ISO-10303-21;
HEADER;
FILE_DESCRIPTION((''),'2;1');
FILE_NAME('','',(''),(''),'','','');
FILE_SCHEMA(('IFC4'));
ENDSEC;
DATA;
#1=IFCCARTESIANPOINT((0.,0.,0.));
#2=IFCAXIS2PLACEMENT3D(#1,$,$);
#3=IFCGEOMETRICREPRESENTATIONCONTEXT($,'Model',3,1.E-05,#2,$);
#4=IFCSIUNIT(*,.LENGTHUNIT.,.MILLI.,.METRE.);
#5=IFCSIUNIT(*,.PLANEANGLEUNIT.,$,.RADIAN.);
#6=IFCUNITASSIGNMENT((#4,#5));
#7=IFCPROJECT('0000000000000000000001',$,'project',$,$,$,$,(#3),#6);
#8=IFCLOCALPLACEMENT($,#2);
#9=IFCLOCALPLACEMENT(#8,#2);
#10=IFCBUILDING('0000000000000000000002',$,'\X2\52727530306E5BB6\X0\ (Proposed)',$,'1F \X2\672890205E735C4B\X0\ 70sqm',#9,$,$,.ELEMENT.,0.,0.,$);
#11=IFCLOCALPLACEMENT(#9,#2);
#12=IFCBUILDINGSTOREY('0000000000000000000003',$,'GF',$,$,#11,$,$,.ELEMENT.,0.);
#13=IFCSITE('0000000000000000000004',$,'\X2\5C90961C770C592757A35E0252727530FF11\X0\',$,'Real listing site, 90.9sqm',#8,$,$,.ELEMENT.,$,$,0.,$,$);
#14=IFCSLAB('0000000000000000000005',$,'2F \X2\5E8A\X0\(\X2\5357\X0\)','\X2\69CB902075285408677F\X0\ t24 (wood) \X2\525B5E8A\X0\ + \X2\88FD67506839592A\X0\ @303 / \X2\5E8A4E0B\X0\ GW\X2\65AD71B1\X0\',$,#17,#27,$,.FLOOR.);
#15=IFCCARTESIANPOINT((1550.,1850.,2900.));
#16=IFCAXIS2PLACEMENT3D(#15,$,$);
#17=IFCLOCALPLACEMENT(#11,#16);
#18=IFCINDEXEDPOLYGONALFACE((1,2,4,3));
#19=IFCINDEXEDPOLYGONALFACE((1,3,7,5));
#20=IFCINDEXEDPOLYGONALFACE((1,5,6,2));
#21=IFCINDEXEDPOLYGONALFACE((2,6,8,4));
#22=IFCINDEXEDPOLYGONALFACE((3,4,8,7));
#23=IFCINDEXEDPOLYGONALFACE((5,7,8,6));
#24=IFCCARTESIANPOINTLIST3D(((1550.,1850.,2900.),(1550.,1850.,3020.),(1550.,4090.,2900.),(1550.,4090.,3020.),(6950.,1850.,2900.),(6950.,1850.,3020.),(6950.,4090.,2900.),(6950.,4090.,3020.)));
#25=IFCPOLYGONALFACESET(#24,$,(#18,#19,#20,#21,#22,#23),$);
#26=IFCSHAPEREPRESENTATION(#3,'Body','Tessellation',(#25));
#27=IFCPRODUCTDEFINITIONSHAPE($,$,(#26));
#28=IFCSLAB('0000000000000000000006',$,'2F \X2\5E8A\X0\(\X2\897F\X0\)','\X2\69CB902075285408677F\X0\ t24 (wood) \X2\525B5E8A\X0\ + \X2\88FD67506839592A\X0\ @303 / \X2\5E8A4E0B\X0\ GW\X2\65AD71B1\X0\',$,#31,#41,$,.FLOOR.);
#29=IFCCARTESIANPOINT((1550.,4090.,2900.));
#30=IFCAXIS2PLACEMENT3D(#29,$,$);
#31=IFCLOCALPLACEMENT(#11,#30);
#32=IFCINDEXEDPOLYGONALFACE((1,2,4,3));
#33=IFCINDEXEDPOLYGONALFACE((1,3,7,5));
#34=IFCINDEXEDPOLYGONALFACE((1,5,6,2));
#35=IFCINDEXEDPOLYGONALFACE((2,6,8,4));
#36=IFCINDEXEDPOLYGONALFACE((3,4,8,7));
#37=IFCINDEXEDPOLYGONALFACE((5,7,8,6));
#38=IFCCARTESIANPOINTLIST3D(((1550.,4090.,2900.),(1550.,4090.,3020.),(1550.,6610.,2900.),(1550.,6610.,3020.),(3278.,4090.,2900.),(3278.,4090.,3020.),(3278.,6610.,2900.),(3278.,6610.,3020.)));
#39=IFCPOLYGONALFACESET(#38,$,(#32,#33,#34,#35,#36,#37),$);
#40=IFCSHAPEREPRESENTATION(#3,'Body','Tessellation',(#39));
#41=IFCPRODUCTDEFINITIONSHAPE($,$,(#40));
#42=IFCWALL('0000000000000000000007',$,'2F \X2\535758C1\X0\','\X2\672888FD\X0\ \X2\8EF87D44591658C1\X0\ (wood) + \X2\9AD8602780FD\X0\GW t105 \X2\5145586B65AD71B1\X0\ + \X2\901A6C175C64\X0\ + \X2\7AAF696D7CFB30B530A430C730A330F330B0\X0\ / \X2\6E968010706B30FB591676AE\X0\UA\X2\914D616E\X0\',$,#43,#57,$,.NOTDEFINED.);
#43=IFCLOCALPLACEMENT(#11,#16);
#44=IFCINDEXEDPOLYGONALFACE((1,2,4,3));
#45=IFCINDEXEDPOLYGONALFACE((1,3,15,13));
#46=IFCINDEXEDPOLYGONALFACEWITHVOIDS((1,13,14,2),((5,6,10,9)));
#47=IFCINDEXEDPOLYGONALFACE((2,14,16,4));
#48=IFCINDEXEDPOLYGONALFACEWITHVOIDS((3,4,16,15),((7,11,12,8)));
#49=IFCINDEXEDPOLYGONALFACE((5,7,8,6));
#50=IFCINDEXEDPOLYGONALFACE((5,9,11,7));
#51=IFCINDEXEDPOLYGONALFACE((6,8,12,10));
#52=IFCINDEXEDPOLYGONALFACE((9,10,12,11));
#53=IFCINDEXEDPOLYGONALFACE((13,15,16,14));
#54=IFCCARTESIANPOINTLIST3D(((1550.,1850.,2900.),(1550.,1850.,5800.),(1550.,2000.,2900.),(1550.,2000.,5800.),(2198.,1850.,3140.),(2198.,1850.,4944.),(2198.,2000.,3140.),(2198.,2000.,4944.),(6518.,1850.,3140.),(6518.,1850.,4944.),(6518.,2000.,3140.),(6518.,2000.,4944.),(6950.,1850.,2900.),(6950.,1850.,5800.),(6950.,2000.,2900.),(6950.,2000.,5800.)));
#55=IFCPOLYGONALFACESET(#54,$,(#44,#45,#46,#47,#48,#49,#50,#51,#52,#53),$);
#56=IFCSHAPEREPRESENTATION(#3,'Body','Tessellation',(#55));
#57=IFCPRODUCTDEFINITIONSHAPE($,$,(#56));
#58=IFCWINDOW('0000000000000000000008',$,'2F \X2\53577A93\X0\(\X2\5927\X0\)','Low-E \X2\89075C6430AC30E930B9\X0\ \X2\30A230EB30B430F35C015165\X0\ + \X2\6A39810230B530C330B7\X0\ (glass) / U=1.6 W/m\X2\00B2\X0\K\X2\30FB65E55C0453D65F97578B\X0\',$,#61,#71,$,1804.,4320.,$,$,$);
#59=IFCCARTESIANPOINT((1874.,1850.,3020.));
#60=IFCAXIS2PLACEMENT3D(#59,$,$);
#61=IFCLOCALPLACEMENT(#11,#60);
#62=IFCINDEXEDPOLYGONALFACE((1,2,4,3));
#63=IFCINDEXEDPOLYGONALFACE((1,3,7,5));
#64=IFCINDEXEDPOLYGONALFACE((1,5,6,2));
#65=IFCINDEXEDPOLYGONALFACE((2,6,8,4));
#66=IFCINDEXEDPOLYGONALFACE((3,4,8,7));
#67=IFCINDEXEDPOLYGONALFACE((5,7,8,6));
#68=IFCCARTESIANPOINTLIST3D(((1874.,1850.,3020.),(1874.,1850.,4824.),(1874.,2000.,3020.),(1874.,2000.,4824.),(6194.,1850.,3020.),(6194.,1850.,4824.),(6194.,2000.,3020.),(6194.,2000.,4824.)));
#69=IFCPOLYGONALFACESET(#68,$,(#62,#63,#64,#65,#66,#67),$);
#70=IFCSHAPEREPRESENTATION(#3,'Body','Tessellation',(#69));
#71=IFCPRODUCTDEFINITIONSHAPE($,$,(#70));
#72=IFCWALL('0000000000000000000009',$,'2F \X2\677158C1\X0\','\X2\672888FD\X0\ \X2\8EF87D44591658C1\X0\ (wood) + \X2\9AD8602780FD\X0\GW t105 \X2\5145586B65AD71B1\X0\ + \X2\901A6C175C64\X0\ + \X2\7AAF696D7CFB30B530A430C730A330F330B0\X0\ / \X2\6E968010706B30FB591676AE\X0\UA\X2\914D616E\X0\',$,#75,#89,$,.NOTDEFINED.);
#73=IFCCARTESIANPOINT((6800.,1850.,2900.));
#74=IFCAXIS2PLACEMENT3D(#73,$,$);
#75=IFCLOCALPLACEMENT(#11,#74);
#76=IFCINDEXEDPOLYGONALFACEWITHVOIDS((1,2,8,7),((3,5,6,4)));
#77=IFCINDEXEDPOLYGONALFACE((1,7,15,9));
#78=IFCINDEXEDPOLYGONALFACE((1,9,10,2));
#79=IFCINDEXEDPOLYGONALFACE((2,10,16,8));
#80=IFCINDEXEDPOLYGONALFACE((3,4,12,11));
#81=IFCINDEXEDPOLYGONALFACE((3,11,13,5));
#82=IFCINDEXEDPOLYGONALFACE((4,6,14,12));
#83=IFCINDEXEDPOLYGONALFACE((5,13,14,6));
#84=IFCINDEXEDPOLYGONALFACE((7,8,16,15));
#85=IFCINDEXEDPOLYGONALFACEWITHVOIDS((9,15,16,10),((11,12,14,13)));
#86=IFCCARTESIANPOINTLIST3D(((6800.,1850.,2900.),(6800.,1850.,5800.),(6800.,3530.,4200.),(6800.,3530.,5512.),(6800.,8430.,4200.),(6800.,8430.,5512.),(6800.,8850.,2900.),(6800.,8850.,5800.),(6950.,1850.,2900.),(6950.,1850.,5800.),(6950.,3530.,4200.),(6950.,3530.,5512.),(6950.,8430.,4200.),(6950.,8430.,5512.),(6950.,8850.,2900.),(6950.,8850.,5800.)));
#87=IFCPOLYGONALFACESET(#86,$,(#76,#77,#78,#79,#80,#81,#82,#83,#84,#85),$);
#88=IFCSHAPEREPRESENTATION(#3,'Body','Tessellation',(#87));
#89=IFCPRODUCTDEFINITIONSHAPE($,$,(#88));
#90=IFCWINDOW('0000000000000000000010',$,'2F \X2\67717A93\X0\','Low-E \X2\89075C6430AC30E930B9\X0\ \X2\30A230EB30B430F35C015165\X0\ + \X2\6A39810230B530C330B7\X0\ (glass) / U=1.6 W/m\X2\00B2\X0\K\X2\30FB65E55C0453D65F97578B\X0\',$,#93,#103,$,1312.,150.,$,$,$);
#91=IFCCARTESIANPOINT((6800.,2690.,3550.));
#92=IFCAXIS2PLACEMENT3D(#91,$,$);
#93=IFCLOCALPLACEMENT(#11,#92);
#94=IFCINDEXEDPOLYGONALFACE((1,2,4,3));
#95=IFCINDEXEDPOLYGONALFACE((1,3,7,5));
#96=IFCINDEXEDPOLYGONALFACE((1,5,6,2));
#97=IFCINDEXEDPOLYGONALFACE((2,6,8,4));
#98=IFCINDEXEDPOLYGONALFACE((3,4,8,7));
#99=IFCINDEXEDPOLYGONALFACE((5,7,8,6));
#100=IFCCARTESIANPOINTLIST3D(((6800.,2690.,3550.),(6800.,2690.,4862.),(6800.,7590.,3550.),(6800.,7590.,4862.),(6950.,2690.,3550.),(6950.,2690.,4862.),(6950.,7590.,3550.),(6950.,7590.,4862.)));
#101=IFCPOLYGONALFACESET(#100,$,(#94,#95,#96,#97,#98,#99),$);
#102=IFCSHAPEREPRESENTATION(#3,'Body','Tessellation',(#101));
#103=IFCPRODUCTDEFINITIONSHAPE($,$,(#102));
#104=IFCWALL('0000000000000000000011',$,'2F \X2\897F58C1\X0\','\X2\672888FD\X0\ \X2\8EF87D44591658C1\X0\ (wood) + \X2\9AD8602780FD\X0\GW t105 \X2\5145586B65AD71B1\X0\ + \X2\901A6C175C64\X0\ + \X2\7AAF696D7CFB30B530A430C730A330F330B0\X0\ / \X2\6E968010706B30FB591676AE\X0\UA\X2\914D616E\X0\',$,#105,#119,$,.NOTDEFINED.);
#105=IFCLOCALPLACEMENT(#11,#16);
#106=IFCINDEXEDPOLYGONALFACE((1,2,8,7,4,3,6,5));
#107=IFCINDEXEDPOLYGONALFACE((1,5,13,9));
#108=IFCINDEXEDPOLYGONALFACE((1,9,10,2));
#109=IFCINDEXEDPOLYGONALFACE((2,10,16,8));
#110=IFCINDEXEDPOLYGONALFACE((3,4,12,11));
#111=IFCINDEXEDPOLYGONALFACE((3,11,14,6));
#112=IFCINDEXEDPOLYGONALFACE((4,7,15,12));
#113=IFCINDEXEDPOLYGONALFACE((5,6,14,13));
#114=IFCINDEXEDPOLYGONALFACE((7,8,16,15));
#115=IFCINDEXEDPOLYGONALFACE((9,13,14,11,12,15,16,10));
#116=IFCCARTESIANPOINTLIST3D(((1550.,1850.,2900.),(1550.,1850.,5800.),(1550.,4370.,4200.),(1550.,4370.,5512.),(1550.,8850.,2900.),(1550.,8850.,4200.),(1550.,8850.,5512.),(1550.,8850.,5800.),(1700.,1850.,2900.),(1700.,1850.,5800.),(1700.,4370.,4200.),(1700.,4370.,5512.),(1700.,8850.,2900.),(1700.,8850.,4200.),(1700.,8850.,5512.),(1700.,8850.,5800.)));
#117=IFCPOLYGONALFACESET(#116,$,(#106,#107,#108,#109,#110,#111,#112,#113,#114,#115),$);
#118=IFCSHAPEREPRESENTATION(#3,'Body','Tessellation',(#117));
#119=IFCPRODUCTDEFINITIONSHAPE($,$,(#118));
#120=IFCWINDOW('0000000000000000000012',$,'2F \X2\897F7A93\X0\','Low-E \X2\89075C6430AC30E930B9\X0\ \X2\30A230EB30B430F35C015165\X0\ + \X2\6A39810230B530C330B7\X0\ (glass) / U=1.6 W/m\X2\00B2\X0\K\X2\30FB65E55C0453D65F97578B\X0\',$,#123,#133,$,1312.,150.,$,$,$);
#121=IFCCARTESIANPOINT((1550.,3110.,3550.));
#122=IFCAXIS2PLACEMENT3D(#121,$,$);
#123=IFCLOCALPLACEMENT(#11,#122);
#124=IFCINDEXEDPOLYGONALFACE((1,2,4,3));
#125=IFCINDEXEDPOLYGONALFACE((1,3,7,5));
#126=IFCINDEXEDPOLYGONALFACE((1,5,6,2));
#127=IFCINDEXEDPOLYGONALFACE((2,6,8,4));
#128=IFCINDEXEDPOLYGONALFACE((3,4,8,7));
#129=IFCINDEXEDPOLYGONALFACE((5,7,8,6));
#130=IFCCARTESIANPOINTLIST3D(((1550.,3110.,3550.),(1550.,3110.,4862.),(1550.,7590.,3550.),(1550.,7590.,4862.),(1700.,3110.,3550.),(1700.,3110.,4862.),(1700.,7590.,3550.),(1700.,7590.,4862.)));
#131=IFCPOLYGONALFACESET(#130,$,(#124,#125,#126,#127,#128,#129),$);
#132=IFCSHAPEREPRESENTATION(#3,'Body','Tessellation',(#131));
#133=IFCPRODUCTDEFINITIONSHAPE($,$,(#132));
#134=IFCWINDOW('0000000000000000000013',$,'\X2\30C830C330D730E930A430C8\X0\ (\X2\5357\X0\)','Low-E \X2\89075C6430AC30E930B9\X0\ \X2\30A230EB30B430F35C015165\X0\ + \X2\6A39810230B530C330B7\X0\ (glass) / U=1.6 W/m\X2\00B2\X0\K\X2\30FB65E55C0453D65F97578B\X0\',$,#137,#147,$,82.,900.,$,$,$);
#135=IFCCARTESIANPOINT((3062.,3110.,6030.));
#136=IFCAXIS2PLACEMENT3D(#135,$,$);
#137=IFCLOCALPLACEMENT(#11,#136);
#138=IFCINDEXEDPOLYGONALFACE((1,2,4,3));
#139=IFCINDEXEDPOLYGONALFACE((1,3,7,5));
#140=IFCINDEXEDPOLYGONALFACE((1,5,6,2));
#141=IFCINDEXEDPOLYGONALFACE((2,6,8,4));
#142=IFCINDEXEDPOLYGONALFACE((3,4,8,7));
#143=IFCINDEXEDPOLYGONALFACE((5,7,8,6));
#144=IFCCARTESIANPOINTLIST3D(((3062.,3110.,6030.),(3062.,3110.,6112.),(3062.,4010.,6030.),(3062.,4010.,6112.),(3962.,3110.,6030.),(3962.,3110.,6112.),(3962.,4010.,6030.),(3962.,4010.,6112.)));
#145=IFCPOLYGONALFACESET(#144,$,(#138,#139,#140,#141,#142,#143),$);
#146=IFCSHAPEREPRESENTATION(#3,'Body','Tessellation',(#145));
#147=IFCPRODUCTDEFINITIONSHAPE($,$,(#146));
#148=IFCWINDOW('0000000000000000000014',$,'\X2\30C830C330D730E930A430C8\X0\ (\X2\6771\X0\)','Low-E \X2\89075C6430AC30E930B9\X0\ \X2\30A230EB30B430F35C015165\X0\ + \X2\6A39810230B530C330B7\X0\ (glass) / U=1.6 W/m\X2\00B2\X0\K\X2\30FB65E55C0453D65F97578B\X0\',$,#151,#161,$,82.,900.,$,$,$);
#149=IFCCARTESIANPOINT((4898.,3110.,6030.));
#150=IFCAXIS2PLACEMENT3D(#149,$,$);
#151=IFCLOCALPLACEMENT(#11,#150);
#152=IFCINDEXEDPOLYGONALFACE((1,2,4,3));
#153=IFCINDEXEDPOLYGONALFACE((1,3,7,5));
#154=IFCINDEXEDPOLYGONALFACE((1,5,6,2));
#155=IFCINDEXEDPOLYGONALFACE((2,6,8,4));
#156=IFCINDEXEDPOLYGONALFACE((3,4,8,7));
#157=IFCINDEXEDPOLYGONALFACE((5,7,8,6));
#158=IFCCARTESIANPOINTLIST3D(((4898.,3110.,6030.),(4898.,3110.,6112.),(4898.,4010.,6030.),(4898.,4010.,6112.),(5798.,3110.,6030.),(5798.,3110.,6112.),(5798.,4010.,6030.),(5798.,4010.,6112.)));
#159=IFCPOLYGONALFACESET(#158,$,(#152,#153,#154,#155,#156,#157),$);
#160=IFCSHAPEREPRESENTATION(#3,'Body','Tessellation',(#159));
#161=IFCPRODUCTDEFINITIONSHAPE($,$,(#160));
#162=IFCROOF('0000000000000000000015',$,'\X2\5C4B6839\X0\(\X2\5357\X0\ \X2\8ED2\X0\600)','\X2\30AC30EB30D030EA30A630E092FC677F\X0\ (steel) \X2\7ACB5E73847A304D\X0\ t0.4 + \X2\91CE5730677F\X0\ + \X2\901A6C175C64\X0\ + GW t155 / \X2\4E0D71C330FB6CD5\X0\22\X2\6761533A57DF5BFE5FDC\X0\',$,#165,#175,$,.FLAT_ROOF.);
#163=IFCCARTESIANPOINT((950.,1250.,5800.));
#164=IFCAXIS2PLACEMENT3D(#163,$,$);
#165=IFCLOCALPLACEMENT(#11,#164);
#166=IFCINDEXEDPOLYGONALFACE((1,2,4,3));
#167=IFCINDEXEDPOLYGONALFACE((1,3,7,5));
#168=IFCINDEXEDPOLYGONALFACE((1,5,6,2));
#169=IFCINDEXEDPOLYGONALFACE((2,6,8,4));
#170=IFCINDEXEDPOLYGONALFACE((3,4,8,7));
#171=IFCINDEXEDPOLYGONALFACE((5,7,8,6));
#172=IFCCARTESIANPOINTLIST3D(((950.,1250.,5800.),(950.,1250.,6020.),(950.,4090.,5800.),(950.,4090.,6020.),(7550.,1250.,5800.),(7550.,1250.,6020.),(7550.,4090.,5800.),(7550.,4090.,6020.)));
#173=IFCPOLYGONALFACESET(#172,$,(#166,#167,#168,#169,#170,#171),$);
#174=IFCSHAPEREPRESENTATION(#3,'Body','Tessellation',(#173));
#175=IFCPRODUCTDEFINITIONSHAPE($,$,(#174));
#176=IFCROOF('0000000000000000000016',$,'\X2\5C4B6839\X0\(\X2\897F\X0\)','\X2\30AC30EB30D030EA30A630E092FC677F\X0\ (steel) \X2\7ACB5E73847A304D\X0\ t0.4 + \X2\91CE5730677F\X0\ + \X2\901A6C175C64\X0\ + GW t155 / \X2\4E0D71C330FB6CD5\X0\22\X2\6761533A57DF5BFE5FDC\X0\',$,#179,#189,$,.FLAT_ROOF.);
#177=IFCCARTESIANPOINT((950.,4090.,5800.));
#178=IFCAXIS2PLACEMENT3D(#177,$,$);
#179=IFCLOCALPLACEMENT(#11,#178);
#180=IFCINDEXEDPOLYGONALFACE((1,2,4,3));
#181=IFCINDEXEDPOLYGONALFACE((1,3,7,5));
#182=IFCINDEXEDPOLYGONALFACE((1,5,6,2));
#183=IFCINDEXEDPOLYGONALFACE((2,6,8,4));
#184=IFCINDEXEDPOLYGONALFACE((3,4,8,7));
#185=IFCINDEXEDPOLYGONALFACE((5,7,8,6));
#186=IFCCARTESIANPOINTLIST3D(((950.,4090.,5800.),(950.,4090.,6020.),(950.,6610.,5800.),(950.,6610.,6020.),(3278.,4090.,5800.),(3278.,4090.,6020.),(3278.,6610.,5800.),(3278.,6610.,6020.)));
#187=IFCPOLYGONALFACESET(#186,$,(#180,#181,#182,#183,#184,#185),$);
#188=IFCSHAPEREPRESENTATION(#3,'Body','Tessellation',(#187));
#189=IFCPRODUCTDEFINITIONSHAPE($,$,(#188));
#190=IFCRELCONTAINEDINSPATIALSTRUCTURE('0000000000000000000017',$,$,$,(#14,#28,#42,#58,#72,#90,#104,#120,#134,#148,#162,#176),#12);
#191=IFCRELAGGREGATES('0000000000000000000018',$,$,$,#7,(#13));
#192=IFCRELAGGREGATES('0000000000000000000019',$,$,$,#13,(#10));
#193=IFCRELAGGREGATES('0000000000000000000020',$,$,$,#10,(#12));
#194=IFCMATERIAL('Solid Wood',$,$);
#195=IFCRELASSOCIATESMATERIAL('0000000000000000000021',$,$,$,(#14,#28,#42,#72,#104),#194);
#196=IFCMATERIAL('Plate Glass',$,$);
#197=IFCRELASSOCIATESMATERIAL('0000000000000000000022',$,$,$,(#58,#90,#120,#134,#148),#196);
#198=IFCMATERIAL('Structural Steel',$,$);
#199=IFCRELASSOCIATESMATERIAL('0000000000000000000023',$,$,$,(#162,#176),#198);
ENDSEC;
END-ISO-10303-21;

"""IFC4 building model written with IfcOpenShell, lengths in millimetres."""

from ifc_helpers import new_model, si_unit, frame, frame_2d, origin, place, context, project, spatial, rectangle, extrude, material, element, fill, save


model = new_model("IFC4")

# Units and contexts
model_context = context("Model", 3, precision=1e-05, world=origin())
ifc_project = project(units=[si_unit("LENGTHUNIT", "METRE", prefix="MILLI"), si_unit("PLANEANGLEUNIT", "RADIAN")], contexts=[model_context])

# Site, building, storey
site_placement = place(None, origin())
site = spatial("IfcSite", under=ifc_project, at=site_placement, Name="岐阜県大垣市割田１", ObjectType="Real listing site, 90.9sqm", CompositionType="ELEMENT", RefElevation=0.0)
building_placement = place(site_placement, origin())
building = spatial("IfcBuilding", under=site, at=building_placement, Name="割田の家 (Proposed)", ObjectType="1F 木造平屋 70sqm", CompositionType="ELEMENT", ElevationOfRefHeight=0.0, ElevationOfTerrain=0.0)
storey_placement = place(building_placement, origin())
storey = spatial("IfcBuildingStorey", under=building, at=storey_placement, Name="GF", CompositionType="ELEMENT", Elevation=0.0)

# Slabs
ifc_material_1 = material(Name="Solid Wood")
slab_1_placement = place(storey_placement, frame((1550.0, 1850.0, 2900.0)))
element("IfcSlab", 1, at=slab_1_placement, inside=storey, material=ifc_material_1, Name="2F 床(南)", Description="構造用合板 t24 (wood) 剛床 + 製材根太 @303 / 床下 GW断熱", PredefinedType="FLOOR", context=model_context, shape_type="SweptSolid", body=[
    extrude(rectangle(XDim=5400.0, YDim=2240.0, at=frame_2d((2700.0, 1120.0))), frame((1550.0, 1850.0, 2900.0)), (0.0, 0.0, 1.0), 120.0),
])
slab_2_placement = place(storey_placement, frame((1550.0, 4090.0, 2900.0)))
element("IfcSlab", 2, at=slab_2_placement, inside=storey, material=ifc_material_1, Name="2F 床(西)", Description="構造用合板 t24 (wood) 剛床 + 製材根太 @303 / 床下 GW断熱", PredefinedType="FLOOR", context=model_context, shape_type="SweptSolid", body=[
    extrude(rectangle(XDim=1728.0, YDim=2520.0, at=frame_2d((864.0, 1260.0))), frame((1550.0, 4090.0, 2900.0)), (0.0, 0.0, 1.0), 120.0),
])

# Walls, openings, windows
wall_1_placement = place(storey_placement, frame((1550.0, 1850.0, 2900.0)))
wall_1 = element("IfcWall", 3, at=wall_1_placement, inside=storey, material=ifc_material_1, Name="2F 南壁", Description="木製 軸組外壁 (wood) + 高性能GW t105 充填断熱 + 通気層 + 窯業系サイディング / 準耐火・外皮UA配慮", PredefinedType="NOTDEFINED", context=model_context, shape_type="SweptSolid", body=[
    extrude(rectangle(XDim=5400.0, YDim=150.0, at=frame_2d((2700.0, 75.0))), frame((1550.0, 1850.0, 2900.0)), (0.0, 0.0, 1.0), 2900.0),
])
opening_1_placement = place(storey_placement, frame((1874.0, 1850.0, 3020.0)))
opening_1 = element("IfcOpeningElement", 4, at=opening_1_placement, cuts=wall_1, PredefinedType="NOTDEFINED", context=model_context, shape_type="SweptSolid", body=[
    extrude(rectangle(XDim=4320.0, YDim=150.0, at=frame_2d((2160.0, 75.0))), frame((1874.0, 1850.0, 3020.0)), (0.0, 0.0, 1.0), 1804.0),
])
ifc_material_2 = material(Name="Plate Glass")
window_1_placement = place(storey_placement, frame((1874.0, 1850.0, 3020.0)))
window_1 = element("IfcWindow", 5, at=window_1_placement, inside=storey, material=ifc_material_2, Name="2F 南窓(大)", Description="Low-E 複層ガラス アルゴン封入 + 樹脂サッシ (glass) / U=1.6 W/m²K・日射取得型", OverallHeight=1804.0, OverallWidth=4320.0, context=model_context, shape_type="SweptSolid", body=[
    extrude(rectangle(XDim=4320.0, YDim=150.0, at=frame_2d((2160.0, 75.0))), frame((1874.0, 1850.0, 3020.0)), (0.0, 0.0, 1.0), 1804.0),
])
fill(opening_1, window_1)
wall_2_placement = place(storey_placement, frame((6800.0, 1850.0, 2900.0)))
wall_2 = element("IfcWall", 6, at=wall_2_placement, inside=storey, material=ifc_material_1, Name="2F 東壁", Description="木製 軸組外壁 (wood) + 高性能GW t105 充填断熱 + 通気層 + 窯業系サイディング / 準耐火・外皮UA配慮", PredefinedType="NOTDEFINED", context=model_context, shape_type="SweptSolid", body=[
    extrude(rectangle(XDim=150.0, YDim=7000.0, at=frame_2d((75.0, 3500.0))), frame((6800.0, 1850.0, 2900.0)), (0.0, 0.0, 1.0), 2900.0),
])
opening_2_placement = place(storey_placement, frame((6800.0, 2690.0, 3550.0)))
opening_2 = element("IfcOpeningElement", 7, at=opening_2_placement, cuts=wall_2, PredefinedType="NOTDEFINED", context=model_context, shape_type="SweptSolid", body=[
    extrude(rectangle(XDim=150.0, YDim=4900.0, at=frame_2d((75.0, 2450.0))), frame((6800.0, 2690.0, 3550.0)), (0.0, 0.0, 1.0), 1312.0),
])
window_2_placement = place(storey_placement, frame((6800.0, 2690.0, 3550.0)))
window_2 = element("IfcWindow", 8, at=window_2_placement, inside=storey, material=ifc_material_2, Name="2F 東窓", Description="Low-E 複層ガラス アルゴン封入 + 樹脂サッシ (glass) / U=1.6 W/m²K・日射取得型", OverallHeight=1312.0, OverallWidth=150.0, context=model_context, shape_type="SweptSolid", body=[
    extrude(rectangle(XDim=150.0, YDim=4900.0, at=frame_2d((75.0, 2450.0))), frame((6800.0, 2690.0, 3550.0)), (0.0, 0.0, 1.0), 1312.0),
])
fill(opening_2, window_2)
wall_3_placement = place(storey_placement, frame((1550.0, 1850.0, 2900.0)))
wall_3 = element("IfcWall", 9, at=wall_3_placement, inside=storey, material=ifc_material_1, Name="2F 西壁", Description="木製 軸組外壁 (wood) + 高性能GW t105 充填断熱 + 通気層 + 窯業系サイディング / 準耐火・外皮UA配慮", PredefinedType="NOTDEFINED", context=model_context, shape_type="SweptSolid", body=[
    extrude(rectangle(XDim=150.0, YDim=7000.0, at=frame_2d((75.0, 3500.0))), frame((1550.0, 1850.0, 2900.0)), (0.0, 0.0, 1.0), 2900.0),
])
opening_3_placement = place(storey_placement, frame((1550.0, 3110.0, 3550.0)))
opening_3 = element("IfcOpeningElement", 10, at=opening_3_placement, cuts=wall_3, PredefinedType="NOTDEFINED", context=model_context, shape_type="SweptSolid", body=[
    extrude(rectangle(XDim=150.0, YDim=4480.0, at=frame_2d((75.0, 2240.0))), frame((1550.0, 3110.0, 3550.0)), (0.0, 0.0, 1.0), 1312.0),
])
window_3_placement = place(storey_placement, frame((1550.0, 3110.0, 3550.0)))
window_3 = element("IfcWindow", 11, at=window_3_placement, inside=storey, material=ifc_material_2, Name="2F 西窓", Description="Low-E 複層ガラス アルゴン封入 + 樹脂サッシ (glass) / U=1.6 W/m²K・日射取得型", OverallHeight=1312.0, OverallWidth=150.0, context=model_context, shape_type="SweptSolid", body=[
    extrude(rectangle(XDim=150.0, YDim=4480.0, at=frame_2d((75.0, 2240.0))), frame((1550.0, 3110.0, 3550.0)), (0.0, 0.0, 1.0), 1312.0),
])
fill(opening_3, window_3)

# Windows
window_4_placement = place(storey_placement, frame((3062.0, 3110.0, 6030.0)))
element("IfcWindow", 12, at=window_4_placement, inside=storey, material=ifc_material_2, Name="トップライト (南)", Description="Low-E 複層ガラス アルゴン封入 + 樹脂サッシ (glass) / U=1.6 W/m²K・日射取得型", OverallHeight=82.0, OverallWidth=900.0, context=model_context, shape_type="SweptSolid", body=[
    extrude(rectangle(XDim=900.0, YDim=900.0, at=frame_2d((450.0, 450.0))), frame((3062.0, 3110.0, 6030.0)), (0.0, 0.0, 1.0), 82.0),
])
window_5_placement = place(storey_placement, frame((4898.0, 3110.0, 6030.0)))
element("IfcWindow", 13, at=window_5_placement, inside=storey, material=ifc_material_2, Name="トップライト (東)", Description="Low-E 複層ガラス アルゴン封入 + 樹脂サッシ (glass) / U=1.6 W/m²K・日射取得型", OverallHeight=82.0, OverallWidth=900.0, context=model_context, shape_type="SweptSolid", body=[
    extrude(rectangle(XDim=900.0, YDim=900.0, at=frame_2d((450.0, 450.0))), frame((4898.0, 3110.0, 6030.0)), (0.0, 0.0, 1.0), 82.0),
])

# Roofs
ifc_material_3 = material(Name="Structural Steel")
roof_1_placement = place(storey_placement, frame((950.0, 1250.0, 5800.0)))
element("IfcRoof", 14, at=roof_1_placement, inside=storey, material=ifc_material_3, Name="屋根(南 軒600)", Description="ガルバリウム鋼板 (steel) 立平葺き t0.4 + 野地板 + 通気層 + GW t155 / 不燃・法22条区域対応", PredefinedType="FLAT_ROOF", context=model_context, shape_type="SweptSolid", body=[
    extrude(rectangle(XDim=6600.0, YDim=2840.0, at=frame_2d((3300.0, 1420.0))), frame((950.0, 1250.0, 5800.0)), (0.0, 0.0, 1.0), 220.0),
])
roof_2_placement = place(storey_placement, frame((950.0, 4090.0, 5800.0)))
element("IfcRoof", 15, at=roof_2_placement, inside=storey, material=ifc_material_3, Name="屋根(西)", Description="ガルバリウム鋼板 (steel) 立平葺き t0.4 + 野地板 + 通気層 + GW t155 / 不燃・法22条区域対応", PredefinedType="FLAT_ROOF", context=model_context, shape_type="SweptSolid", body=[
    extrude(rectangle(XDim=2328.0, YDim=2520.0, at=frame_2d((1164.0, 1260.0))), frame((950.0, 4090.0, 5800.0)), (0.0, 0.0, 1.0), 220.0),
])

save(model, "model.ifc")
